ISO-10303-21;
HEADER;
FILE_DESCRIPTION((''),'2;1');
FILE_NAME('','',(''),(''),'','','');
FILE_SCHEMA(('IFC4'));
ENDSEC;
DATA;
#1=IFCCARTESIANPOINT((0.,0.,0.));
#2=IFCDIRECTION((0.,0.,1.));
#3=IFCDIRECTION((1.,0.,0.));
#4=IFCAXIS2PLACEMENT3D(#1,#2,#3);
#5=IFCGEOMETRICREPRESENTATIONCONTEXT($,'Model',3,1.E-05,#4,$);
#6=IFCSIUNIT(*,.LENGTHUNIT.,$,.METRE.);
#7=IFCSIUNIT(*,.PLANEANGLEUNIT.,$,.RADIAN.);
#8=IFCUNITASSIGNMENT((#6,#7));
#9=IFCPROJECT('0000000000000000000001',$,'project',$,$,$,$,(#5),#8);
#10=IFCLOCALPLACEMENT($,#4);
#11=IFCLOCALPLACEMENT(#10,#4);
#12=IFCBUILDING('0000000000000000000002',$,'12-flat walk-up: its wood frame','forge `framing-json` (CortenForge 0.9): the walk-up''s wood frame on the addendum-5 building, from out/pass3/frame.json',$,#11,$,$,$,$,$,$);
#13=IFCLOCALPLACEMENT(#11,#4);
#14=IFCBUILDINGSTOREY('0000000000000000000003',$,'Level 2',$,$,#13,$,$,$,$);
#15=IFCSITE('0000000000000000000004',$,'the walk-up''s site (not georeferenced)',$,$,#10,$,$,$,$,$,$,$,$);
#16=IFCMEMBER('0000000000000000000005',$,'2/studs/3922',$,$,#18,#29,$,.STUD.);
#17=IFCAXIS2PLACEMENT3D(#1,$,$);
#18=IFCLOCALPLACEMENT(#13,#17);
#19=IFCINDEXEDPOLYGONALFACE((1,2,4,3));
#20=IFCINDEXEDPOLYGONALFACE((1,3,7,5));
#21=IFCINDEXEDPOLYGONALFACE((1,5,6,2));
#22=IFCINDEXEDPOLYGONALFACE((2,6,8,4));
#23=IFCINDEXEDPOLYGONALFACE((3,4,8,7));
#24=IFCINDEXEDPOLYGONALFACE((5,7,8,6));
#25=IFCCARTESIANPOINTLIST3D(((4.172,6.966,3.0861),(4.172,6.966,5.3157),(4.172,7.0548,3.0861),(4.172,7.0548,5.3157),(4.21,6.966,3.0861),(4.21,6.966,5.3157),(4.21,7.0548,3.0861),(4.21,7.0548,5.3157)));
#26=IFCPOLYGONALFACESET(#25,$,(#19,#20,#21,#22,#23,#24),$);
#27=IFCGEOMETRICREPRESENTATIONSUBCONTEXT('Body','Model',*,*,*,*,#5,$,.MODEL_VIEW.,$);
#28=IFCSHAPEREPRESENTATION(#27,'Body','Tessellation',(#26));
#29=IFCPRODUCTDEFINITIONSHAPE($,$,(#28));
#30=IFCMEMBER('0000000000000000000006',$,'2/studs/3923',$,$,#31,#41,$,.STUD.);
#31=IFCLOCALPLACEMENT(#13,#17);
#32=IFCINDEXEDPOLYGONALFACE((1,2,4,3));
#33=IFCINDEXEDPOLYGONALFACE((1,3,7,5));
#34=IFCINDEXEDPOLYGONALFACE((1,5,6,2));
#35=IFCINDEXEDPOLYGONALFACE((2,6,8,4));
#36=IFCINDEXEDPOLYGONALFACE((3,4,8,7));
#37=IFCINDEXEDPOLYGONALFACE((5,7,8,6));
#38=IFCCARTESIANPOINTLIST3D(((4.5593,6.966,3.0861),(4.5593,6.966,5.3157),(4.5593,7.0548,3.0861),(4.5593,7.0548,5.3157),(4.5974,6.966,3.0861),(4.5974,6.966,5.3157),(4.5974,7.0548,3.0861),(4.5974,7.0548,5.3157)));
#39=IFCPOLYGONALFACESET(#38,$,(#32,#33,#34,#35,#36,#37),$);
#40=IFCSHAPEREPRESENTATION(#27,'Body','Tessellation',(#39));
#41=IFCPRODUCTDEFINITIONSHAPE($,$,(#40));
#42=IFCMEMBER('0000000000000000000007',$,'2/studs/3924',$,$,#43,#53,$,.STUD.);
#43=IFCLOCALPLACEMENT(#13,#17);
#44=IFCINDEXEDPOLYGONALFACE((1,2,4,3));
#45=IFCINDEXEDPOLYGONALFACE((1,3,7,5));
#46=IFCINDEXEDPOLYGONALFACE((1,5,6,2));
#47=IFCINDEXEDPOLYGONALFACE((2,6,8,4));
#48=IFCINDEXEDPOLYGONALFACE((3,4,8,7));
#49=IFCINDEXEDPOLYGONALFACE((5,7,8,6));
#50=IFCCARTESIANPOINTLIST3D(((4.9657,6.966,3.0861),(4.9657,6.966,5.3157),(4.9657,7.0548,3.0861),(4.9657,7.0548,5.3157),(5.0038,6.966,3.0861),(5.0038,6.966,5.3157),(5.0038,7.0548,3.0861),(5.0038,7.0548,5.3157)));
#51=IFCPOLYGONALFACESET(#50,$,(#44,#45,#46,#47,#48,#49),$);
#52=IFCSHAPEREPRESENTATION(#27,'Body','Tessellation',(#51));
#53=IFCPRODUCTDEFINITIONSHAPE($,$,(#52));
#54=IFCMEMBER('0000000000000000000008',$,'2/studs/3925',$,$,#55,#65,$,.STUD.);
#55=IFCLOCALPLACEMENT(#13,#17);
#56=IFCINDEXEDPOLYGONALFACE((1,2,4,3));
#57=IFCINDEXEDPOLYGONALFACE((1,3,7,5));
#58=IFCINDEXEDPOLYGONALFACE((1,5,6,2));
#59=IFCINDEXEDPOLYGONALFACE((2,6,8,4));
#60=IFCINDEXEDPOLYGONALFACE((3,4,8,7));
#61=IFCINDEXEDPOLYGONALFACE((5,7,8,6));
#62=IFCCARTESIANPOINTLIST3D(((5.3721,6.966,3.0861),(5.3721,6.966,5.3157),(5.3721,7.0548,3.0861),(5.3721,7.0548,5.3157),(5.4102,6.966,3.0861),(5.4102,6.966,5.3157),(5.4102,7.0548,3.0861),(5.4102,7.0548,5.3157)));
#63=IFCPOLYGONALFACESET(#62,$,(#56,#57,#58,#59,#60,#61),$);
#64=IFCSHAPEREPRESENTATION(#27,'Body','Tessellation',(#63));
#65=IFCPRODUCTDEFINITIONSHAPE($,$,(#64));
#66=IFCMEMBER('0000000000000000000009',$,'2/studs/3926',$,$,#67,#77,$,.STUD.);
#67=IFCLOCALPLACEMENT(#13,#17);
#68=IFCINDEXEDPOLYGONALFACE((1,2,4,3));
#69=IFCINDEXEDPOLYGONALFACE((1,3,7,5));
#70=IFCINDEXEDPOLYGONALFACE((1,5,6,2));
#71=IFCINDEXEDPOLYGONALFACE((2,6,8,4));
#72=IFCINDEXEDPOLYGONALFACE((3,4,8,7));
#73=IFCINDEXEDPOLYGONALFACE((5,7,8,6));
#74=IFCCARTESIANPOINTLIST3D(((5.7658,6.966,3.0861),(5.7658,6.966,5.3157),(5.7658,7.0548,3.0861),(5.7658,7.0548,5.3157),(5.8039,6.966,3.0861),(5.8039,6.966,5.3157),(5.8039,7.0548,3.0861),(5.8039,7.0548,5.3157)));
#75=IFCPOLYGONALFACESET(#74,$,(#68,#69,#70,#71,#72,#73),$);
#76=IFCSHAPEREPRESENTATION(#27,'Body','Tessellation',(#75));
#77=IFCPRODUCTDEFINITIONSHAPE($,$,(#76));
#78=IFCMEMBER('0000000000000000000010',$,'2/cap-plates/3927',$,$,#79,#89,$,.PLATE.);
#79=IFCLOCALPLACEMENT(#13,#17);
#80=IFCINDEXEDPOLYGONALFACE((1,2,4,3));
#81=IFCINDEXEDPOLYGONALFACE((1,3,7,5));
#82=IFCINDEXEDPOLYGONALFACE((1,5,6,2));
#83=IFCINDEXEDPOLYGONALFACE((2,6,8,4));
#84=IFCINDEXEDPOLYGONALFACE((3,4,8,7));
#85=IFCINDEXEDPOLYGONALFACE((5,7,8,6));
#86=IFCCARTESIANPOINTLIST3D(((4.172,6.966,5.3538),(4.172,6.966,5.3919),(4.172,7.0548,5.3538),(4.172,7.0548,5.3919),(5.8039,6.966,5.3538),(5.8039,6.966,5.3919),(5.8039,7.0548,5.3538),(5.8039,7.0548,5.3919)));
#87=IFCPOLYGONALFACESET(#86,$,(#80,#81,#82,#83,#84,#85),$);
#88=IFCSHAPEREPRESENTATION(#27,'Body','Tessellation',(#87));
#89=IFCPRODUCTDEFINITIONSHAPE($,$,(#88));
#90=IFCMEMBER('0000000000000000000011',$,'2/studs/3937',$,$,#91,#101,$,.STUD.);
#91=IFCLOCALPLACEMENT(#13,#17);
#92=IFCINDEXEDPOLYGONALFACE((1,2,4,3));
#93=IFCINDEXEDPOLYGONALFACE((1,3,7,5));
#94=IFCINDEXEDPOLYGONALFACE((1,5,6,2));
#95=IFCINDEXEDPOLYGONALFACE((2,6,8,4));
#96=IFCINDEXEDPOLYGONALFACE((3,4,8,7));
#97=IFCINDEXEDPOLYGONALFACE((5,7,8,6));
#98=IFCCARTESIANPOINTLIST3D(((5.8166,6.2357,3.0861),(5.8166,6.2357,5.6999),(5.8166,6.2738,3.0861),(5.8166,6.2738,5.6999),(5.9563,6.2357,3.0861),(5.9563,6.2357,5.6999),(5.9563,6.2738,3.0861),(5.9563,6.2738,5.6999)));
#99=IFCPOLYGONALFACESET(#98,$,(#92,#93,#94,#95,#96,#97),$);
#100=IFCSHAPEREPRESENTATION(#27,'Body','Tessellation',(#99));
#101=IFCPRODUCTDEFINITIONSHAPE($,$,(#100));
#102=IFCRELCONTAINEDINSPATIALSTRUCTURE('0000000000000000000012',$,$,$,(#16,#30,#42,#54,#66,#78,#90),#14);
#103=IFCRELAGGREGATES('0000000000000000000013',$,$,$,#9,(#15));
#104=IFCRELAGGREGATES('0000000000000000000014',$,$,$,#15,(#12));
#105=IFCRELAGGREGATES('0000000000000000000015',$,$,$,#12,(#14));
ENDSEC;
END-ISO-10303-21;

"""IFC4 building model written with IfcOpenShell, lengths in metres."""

from ifc_helpers import new_model, si_unit, frame, frame_2d, origin, origin_with_axes, place, context, subcontext, project, spatial, rectangle, extrude, element, save


model = new_model("IFC4")

# Units and contexts
model_context = context("Model", 3, precision=1e-05, world=origin_with_axes())
body_context = subcontext(model_context, "Body", "Model", "MODEL_VIEW")
ifc_project = project(units=[si_unit("LENGTHUNIT", "METRE"), si_unit("PLANEANGLEUNIT", "RADIAN")], contexts=[model_context])

# Site, building, storey
site_placement = place(None, origin_with_axes())
site = spatial("IfcSite", under=ifc_project, at=site_placement, Name="the walk-up's site (not georeferenced)")
building_placement = place(site_placement, origin_with_axes())
building = spatial("IfcBuilding", under=site, at=building_placement, Name="12-flat walk-up: its wood frame", Description="forge `framing-json` (CortenForge 0.9): the walk-up's wood frame on the addendum-5 building, from out/pass3/frame.json")
storey_placement = place(building_placement, origin_with_axes())
storey = spatial("IfcBuildingStorey", under=building, at=storey_placement, Name="Level 2")

# Members
for number, where, z_axis, x_axis, name in (
    (1, (4.1719, 6.966, 3.0861), (0.0, 0.0, 1.0), (1.0, 0.0, 0.0), "2/studs/3922"),
    (2, (4.5593, 6.966, 3.0861), (0.0, 0.0, 1.0), (1.0, 0.0, 0.0), "2/studs/3923"),
    (3, (4.9657, 6.966, 3.0861), (0.0, 0.0, 1.0), (1.0, 0.0, 0.0), "2/studs/3924"),
    (4, (5.3721, 6.966, 3.0861), (0.0, 0.0, 1.0), (1.0, 0.0, 0.0), "2/studs/3925"),
    (5, (5.7658, 6.966, 3.0861), (0.0, 0.0, 1.0), (1.0, 0.0, 0.0), "2/studs/3926"),
):
    element("IfcMember", number, at=place(storey_placement, frame(where, z_axis=z_axis, x_axis=x_axis)), inside=storey, Name=name, PredefinedType="STUD", context=body_context, shape_type="SweptSolid", body=[
        extrude(rectangle(XDim=0.0381, YDim=0.0889, at=frame_2d((0.0191, 0.0444))), origin(), (0.0, 0.0, 1.0), 2.2296),
    ])
member_1_placement = place(storey_placement, frame((4.1719, 6.966, 5.3538), z_axis=(0.0, 0.0, 1.0), x_axis=(1.0, 0.0, 0.0)))
element("IfcMember", 6, at=member_1_placement, inside=storey, Name="2/cap-plates/3927", PredefinedType="PLATE", context=body_context, shape_type="SweptSolid", body=[
    extrude(rectangle(XDim=1.6319, YDim=0.0889, at=frame_2d((0.816, 0.0444))), origin(), (0.0, 0.0, 1.0), 0.0381),
])
member_2_placement = place(storey_placement, frame((5.8166, 6.2357, 3.0861), z_axis=(0.0, 0.0, 1.0), x_axis=(1.0, 0.0, 0.0)))
element("IfcMember", 7, at=member_2_placement, inside=storey, Name="2/studs/3937", PredefinedType="STUD", context=body_context, shape_type="SweptSolid", body=[
    extrude(rectangle(XDim=0.1397, YDim=0.0381, at=frame_2d((0.0698, 0.0191))), origin(), (0.0, 0.0, 1.0), 2.6138),
])

save(model, "model.ifc")
